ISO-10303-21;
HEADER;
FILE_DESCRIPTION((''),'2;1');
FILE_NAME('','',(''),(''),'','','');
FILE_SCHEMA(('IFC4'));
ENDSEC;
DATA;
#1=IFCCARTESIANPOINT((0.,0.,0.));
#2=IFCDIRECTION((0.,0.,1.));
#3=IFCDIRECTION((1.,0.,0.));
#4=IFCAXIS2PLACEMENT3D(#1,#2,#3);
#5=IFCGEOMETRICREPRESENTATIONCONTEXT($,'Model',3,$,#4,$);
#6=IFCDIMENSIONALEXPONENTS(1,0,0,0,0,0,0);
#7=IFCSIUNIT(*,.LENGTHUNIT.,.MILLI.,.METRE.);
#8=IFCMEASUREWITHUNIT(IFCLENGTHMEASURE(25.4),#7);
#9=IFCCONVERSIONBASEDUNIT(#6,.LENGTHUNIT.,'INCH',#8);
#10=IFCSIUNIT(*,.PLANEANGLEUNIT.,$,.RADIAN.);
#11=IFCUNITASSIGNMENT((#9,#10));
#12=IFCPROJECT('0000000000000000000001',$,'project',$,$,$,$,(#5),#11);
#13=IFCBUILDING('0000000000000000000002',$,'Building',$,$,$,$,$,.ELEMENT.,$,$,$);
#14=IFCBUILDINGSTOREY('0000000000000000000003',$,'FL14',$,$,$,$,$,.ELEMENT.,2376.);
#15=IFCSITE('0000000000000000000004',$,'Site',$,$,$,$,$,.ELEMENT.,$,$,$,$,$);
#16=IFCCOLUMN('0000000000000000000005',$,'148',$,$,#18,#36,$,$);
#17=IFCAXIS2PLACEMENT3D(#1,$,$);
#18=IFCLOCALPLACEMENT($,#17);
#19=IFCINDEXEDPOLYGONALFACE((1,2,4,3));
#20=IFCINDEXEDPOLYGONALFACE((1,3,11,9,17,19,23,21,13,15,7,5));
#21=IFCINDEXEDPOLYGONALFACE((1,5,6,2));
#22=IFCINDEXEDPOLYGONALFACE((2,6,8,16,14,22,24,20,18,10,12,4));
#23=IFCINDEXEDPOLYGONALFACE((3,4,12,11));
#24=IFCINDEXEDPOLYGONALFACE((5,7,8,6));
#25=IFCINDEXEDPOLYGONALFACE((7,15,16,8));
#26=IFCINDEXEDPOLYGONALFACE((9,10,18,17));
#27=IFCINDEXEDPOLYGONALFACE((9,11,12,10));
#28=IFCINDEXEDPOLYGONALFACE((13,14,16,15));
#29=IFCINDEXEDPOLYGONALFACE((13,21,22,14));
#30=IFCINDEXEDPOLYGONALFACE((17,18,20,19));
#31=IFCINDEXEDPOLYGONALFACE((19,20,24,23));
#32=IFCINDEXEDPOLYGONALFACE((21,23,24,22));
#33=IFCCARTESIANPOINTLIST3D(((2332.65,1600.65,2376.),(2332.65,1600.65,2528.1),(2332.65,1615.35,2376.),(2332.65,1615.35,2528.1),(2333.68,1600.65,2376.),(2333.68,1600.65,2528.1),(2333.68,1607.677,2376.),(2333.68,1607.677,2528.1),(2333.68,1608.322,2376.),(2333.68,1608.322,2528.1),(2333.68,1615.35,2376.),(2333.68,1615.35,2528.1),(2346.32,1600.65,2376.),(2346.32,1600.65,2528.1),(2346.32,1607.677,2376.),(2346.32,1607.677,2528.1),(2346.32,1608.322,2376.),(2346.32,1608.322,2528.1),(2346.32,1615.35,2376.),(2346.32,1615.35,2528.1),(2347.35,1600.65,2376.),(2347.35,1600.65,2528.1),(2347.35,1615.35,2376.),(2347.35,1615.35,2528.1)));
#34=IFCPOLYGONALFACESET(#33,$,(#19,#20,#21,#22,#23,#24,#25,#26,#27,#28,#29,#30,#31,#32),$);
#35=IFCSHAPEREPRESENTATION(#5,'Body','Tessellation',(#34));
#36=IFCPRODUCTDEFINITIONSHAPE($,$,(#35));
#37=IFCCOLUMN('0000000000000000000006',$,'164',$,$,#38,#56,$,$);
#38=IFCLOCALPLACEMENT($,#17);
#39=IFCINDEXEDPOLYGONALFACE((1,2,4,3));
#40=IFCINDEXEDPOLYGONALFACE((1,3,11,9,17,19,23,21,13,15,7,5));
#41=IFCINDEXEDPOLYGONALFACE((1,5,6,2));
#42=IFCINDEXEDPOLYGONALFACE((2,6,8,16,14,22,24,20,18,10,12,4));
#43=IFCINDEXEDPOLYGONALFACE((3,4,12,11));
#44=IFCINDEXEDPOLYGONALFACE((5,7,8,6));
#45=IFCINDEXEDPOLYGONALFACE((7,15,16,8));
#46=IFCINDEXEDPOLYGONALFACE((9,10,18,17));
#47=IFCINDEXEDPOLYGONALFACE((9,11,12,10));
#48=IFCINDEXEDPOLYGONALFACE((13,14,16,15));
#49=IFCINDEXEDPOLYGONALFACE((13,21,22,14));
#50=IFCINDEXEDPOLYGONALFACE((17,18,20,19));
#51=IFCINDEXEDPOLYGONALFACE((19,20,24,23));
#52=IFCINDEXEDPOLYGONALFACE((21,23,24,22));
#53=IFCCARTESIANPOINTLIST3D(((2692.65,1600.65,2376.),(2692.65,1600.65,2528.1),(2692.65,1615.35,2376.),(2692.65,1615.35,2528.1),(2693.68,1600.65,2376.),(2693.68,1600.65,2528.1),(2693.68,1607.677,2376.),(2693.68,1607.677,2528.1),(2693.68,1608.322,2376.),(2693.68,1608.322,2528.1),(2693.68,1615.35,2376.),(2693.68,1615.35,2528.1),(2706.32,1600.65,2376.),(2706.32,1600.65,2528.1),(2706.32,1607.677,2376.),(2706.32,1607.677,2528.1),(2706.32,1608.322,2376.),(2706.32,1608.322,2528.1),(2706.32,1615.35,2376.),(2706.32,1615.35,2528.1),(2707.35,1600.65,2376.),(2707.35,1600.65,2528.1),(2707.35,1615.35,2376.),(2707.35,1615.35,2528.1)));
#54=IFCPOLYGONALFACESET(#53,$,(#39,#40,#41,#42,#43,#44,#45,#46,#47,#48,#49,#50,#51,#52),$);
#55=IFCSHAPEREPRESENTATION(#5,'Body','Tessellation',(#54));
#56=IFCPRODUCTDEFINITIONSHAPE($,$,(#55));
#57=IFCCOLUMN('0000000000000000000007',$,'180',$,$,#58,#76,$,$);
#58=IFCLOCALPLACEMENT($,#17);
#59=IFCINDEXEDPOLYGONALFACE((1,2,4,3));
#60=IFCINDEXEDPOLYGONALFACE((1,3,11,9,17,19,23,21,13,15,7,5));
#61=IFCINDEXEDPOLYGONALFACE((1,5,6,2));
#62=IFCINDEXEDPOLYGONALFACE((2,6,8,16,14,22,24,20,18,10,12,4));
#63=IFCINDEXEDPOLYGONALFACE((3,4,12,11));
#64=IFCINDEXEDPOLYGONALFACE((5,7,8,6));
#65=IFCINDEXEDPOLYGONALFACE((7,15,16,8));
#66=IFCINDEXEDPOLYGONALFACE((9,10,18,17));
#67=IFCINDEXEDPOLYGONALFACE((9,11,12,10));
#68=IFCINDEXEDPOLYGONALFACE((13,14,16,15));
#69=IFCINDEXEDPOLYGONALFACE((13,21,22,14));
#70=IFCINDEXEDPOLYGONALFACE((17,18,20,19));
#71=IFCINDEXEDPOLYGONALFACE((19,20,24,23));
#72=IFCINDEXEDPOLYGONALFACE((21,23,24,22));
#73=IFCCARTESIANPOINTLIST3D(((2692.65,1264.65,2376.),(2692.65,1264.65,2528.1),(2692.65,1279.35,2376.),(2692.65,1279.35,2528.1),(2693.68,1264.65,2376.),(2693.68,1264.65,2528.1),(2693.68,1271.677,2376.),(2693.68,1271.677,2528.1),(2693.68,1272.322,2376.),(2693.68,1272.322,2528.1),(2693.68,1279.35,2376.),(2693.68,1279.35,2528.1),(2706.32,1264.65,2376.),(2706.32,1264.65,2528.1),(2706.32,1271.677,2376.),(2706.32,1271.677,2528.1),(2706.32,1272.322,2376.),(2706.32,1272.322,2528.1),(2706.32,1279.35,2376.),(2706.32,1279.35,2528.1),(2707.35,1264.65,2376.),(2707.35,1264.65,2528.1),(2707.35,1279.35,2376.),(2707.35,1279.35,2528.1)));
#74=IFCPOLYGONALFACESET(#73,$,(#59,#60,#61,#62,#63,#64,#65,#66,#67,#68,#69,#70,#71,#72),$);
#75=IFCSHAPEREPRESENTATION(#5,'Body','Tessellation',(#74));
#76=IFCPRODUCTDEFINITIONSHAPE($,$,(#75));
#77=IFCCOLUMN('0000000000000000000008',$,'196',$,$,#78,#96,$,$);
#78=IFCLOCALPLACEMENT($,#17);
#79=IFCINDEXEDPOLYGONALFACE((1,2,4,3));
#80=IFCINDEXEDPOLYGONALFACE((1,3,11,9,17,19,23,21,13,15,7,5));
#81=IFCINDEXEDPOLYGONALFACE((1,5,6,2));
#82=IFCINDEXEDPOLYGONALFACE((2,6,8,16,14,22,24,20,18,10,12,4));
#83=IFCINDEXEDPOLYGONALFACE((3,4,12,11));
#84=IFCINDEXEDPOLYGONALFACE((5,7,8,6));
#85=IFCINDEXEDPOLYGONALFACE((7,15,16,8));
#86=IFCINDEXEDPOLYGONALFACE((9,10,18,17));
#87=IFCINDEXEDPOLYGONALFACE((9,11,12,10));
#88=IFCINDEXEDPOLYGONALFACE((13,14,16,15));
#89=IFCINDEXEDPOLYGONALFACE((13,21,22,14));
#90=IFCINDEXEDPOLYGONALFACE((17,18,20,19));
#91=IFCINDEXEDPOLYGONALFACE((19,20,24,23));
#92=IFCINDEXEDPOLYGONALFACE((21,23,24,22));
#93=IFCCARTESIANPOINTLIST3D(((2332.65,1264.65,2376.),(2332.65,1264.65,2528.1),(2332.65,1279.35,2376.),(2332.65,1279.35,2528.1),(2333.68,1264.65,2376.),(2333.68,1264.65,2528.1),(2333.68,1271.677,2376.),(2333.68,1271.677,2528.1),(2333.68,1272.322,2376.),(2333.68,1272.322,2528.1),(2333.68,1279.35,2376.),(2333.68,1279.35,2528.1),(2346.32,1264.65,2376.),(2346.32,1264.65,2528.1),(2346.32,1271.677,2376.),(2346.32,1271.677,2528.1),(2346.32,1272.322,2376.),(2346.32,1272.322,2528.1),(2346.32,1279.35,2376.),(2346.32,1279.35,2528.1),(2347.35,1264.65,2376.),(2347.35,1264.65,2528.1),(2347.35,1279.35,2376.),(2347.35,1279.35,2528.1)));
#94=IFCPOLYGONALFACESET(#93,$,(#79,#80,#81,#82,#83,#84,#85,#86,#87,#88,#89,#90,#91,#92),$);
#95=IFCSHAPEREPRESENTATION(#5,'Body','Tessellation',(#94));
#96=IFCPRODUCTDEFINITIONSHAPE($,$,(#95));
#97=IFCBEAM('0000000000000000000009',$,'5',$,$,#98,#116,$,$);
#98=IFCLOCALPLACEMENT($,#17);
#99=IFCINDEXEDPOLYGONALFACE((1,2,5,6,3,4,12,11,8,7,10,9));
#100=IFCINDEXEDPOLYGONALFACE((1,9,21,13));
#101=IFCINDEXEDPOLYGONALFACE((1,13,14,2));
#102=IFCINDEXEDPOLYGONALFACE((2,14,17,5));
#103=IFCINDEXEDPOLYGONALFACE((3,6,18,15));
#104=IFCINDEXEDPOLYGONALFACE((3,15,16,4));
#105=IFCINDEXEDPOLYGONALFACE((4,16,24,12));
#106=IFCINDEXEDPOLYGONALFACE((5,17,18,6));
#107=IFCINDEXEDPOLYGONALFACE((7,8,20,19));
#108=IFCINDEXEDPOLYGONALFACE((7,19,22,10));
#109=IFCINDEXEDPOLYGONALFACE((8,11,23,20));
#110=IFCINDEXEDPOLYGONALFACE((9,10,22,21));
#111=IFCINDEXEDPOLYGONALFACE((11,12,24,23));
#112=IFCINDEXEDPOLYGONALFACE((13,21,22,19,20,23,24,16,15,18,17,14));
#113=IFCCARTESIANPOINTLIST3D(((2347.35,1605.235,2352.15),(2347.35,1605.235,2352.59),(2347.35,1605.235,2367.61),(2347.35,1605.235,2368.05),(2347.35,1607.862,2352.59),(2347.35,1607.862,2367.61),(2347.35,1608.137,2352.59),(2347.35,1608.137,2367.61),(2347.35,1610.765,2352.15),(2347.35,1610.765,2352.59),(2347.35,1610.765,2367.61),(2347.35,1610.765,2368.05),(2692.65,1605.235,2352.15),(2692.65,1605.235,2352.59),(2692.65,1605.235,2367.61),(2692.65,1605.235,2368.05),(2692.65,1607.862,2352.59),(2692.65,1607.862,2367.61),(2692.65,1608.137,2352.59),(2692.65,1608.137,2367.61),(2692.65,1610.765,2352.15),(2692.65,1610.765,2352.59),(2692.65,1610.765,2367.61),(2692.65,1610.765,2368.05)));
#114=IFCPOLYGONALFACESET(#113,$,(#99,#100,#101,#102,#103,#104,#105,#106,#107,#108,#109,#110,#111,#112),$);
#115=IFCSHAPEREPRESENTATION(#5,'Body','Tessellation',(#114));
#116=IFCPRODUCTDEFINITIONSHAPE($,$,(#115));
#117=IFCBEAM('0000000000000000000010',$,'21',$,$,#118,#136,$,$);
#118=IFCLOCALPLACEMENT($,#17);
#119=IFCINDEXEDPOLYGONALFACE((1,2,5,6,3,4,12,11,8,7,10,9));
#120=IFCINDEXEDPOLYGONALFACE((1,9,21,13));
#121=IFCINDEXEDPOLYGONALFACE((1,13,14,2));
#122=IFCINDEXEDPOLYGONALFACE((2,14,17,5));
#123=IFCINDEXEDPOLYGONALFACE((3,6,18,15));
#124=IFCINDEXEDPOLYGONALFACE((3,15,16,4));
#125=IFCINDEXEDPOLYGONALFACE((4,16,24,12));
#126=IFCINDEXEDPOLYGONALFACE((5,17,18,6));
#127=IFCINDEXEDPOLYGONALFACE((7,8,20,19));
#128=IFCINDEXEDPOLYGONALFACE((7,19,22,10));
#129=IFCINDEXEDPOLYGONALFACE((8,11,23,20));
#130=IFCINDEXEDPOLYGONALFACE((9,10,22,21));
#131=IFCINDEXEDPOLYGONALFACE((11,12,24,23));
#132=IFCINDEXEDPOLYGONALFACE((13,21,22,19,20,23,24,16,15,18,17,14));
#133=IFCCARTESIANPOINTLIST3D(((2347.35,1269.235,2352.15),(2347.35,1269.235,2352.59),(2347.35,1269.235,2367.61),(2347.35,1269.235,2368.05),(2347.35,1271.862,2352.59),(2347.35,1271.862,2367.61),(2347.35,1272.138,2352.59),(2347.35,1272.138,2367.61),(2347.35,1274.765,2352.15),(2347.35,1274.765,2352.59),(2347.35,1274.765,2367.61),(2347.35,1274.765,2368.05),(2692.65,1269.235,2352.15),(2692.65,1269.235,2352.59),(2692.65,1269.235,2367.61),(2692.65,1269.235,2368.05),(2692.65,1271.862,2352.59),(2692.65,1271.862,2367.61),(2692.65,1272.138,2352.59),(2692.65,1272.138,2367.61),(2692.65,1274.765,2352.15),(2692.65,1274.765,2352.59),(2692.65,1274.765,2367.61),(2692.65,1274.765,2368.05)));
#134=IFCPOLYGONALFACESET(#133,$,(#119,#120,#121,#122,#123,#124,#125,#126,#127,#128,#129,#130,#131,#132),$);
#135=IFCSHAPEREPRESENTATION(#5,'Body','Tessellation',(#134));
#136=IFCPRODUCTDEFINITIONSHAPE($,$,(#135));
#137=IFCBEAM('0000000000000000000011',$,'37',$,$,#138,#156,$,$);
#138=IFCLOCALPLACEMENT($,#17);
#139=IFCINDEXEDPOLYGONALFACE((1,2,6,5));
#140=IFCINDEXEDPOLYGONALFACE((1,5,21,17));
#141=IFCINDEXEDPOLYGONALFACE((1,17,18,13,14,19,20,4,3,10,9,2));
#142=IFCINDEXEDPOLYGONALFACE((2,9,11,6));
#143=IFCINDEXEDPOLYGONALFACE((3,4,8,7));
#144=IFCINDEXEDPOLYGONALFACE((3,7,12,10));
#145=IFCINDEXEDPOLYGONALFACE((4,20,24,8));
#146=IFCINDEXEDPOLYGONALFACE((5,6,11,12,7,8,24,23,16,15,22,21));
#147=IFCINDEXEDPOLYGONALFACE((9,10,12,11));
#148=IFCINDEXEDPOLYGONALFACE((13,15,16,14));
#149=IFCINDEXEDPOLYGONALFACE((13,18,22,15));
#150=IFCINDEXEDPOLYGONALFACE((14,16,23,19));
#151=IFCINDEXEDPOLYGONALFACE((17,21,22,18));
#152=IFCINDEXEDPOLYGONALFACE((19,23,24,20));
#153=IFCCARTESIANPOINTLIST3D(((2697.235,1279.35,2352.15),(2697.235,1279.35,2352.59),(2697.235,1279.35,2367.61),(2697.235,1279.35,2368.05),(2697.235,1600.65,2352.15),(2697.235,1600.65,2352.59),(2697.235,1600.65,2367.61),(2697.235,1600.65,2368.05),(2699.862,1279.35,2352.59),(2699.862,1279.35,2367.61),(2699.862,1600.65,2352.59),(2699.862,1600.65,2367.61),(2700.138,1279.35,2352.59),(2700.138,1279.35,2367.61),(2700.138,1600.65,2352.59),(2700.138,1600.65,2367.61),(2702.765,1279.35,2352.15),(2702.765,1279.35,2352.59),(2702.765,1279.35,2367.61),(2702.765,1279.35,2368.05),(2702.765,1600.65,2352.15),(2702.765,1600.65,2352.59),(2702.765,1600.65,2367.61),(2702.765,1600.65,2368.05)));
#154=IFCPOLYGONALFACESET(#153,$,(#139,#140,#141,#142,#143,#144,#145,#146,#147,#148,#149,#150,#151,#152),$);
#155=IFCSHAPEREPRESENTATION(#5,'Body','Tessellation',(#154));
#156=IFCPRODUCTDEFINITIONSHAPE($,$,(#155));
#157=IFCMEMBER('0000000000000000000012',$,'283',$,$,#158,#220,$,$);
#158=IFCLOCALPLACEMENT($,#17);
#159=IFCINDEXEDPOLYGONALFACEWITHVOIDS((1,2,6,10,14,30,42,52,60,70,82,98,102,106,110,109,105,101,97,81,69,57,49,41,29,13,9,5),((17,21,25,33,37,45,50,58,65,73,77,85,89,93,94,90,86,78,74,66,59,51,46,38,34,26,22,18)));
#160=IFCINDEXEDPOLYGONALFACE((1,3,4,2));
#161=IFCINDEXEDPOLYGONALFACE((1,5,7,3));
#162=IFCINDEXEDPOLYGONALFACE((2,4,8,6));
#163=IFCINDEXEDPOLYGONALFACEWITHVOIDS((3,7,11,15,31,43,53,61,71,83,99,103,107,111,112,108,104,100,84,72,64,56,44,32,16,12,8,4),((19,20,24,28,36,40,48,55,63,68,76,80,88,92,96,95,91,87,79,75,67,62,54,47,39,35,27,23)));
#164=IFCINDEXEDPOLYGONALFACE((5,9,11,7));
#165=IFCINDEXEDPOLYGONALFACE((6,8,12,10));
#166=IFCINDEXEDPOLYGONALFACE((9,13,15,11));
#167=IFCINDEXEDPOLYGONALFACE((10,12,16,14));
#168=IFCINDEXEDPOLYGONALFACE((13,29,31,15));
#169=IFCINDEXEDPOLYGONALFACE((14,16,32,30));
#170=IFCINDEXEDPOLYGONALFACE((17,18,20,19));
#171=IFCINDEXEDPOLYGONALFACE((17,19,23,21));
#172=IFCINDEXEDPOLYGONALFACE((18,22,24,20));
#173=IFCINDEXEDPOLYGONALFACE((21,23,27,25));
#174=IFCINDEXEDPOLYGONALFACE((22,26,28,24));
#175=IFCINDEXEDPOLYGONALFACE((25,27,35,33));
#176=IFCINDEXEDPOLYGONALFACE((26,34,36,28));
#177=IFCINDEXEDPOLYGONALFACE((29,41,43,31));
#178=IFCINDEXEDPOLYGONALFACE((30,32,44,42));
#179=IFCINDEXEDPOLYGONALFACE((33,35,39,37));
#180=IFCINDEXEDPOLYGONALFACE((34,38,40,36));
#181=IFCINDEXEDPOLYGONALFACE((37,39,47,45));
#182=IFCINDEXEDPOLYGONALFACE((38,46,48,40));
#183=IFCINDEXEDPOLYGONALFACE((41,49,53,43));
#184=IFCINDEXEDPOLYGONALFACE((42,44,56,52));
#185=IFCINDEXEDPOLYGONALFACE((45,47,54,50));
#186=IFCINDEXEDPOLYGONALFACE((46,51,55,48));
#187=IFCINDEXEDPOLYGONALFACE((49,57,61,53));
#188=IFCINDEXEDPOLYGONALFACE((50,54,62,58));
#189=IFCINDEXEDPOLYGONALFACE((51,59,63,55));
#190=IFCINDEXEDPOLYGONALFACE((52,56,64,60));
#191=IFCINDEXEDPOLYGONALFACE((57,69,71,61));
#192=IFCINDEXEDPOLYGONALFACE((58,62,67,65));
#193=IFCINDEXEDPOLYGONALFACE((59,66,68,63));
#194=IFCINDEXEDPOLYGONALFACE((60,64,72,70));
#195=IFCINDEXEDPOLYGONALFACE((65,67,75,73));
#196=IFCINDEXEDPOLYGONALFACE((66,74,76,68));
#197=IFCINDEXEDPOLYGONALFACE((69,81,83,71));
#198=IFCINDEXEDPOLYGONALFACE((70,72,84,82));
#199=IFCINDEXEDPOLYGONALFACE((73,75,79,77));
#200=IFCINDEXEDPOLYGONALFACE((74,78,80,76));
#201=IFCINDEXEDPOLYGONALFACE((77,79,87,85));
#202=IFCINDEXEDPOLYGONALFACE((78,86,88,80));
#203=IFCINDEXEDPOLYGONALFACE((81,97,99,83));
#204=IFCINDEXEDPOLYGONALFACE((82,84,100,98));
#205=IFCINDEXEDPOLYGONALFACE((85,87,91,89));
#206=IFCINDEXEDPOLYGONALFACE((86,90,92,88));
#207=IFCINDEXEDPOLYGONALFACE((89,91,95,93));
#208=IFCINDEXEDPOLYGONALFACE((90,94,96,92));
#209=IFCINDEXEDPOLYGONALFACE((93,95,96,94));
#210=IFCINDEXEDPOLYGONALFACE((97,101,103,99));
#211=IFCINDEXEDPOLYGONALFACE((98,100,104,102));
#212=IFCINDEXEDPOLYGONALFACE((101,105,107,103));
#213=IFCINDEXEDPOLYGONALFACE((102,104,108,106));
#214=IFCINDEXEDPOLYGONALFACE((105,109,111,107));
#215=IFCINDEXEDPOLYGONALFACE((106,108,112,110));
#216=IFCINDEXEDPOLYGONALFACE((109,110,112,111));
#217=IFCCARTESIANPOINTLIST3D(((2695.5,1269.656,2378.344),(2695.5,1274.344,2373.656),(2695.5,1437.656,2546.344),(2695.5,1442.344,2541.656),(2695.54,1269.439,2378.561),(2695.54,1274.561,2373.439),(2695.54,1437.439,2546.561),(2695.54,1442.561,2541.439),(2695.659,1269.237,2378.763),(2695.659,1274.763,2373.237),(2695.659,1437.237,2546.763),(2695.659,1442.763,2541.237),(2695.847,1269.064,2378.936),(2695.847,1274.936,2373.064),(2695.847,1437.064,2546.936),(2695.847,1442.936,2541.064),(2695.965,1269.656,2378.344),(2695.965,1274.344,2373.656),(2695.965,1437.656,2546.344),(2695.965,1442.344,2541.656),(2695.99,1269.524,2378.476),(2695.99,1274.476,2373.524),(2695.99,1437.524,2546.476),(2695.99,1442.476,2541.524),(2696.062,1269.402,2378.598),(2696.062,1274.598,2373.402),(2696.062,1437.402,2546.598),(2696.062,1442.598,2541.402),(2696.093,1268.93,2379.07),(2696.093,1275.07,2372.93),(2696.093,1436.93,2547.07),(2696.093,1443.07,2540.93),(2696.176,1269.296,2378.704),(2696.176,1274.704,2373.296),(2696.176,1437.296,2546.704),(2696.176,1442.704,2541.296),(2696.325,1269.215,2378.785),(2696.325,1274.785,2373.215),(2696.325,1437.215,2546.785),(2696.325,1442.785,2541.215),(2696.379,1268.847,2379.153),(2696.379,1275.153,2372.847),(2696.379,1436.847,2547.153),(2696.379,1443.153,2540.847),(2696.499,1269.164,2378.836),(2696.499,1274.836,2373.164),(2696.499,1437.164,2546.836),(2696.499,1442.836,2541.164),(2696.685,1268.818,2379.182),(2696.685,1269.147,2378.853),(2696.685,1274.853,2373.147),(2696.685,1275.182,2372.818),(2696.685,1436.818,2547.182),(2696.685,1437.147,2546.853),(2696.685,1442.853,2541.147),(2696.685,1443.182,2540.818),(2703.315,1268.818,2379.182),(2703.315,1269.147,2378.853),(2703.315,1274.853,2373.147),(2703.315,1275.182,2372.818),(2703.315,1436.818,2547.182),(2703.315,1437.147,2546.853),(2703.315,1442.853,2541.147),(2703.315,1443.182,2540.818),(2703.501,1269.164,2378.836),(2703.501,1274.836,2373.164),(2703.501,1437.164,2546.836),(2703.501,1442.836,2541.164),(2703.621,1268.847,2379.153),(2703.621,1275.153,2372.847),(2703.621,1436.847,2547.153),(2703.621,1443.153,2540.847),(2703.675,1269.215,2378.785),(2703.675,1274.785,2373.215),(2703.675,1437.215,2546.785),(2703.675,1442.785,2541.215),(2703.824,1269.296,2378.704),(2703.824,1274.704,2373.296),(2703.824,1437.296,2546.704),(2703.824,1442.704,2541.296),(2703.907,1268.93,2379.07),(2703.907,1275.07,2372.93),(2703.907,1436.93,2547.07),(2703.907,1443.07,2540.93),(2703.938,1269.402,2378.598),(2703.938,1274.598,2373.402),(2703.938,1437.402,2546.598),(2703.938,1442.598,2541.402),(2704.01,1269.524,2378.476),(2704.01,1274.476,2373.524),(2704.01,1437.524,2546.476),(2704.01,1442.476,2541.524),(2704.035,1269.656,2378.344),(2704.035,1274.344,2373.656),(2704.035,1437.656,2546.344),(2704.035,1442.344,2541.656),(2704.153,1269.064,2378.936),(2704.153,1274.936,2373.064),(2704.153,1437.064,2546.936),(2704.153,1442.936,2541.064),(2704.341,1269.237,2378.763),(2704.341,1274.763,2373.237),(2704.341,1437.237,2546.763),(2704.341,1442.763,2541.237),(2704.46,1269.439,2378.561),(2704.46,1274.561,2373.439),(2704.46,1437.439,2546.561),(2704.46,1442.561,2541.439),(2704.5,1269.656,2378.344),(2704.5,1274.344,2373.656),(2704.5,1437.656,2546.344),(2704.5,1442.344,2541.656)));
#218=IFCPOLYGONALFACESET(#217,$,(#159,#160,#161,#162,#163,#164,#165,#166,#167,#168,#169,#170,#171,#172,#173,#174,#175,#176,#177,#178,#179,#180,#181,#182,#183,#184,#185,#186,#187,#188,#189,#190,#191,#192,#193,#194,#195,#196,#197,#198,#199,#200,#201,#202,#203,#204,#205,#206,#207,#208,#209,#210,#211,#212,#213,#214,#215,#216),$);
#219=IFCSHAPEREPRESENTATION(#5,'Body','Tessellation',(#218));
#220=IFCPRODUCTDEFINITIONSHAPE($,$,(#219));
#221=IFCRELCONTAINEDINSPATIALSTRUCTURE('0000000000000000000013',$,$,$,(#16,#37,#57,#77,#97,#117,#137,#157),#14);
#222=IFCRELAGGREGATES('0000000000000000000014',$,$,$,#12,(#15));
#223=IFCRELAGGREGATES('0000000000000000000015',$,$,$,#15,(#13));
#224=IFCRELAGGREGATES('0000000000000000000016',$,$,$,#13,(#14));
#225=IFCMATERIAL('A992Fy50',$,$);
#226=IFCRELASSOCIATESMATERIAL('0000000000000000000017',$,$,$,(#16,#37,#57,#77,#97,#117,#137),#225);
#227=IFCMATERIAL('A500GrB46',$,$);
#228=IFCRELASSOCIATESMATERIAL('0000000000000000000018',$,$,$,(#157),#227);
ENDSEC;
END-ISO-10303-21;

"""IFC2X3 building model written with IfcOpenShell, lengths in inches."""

from ifc_helpers import new_model, entity, si_unit, converted_unit, frame, origin_with_axes, origin_2d_with_axis, place, context, project, spatial, hollow_rectangle, i_section, transform_2d, derived_profile, extrude, material, element, save


model = new_model("IFC2X3")

# Units and contexts
model_context = context("Model", 3, world=origin_with_axes())
ifc_project = project(units=[converted_unit("LENGTHUNIT", "INCH", entity("IfcLengthMeasure", 25.4), si_unit("LENGTHUNIT", "METRE", prefix="MILLI"), dimensions=[1, 0, 0, 0, 0, 0, 0]), si_unit("PLANEANGLEUNIT", "RADIAN")], contexts=[model_context])

# Site, building, storey
site = spatial("IfcSite", under=ifc_project, Name="Site", CompositionType="ELEMENT")
building = spatial("IfcBuilding", under=site, Name="Building", CompositionType="ELEMENT")
storey = spatial("IfcBuildingStorey", under=building, Name="FL14", CompositionType="ELEMENT", Elevation=2376.0)

# Columns
ifc_material_1 = material(Name="A992Fy50")
for number, where, z_axis, x_axis, name in (
    (1, (2340.0, 1608.0, 2376.0), (0.0, 0.0, 1.0), (0.0, -1.0, 0.0), "148"),
    (2, (2700.0, 1608.0, 2376.0), (0.0, 0.0, 1.0), (0.0, -1.0, 0.0), "164"),
    (3, (2700.0, 1272.0, 2376.0), (0.0, 0.0, 1.0), (0.0, -1.0, 0.0), "180"),
    (4, (2340.0, 1272.0, 2376.0), (0.0, 0.0, 1.0), (0.0, -1.0, 0.0), "196"),
):
    element("IfcColumn", number, at=place(None, frame(where, z_axis=z_axis, x_axis=x_axis)), inside=storey, material=ifc_material_1, Name=name, context=model_context, shape_type="SweptSolid", body=[
        extrude(i_section(OverallWidth=14.7, OverallDepth=14.7, WebThickness=0.645, FlangeThickness=1.03, at=origin_2d_with_axis()), origin_with_axes(), (0.0, 0.0, 1.0), 152.1),
    ])

# Beams
for number, where, z_axis, x_axis, name in (
    (5, (2347.35, 1608.0, 2376.0), (1.0, 0.0, 0.0), (0.0, 1.0, 0.0), "5"),
    (6, (2347.35, 1272.0, 2376.0), (1.0, 0.0, 0.0), (0.0, 1.0, 0.0), "21"),
):
    element("IfcBeam", number, at=place(None, frame(where, z_axis=z_axis, x_axis=x_axis)), inside=storey, material=ifc_material_1, Name=name, context=model_context, shape_type="SweptSolid", body=[
        extrude(derived_profile(i_section(OverallWidth=5.53, OverallDepth=15.9, WebThickness=0.275, FlangeThickness=0.44, at=origin_2d_with_axis()), transform_2d((0.0, -7.95))), origin_with_axes(), (0.0, 0.0, 1.0), 345.3),
    ])
beam_placement = place(None, frame((2700.0, 1279.35, 2376.0), z_axis=(0.0, 1.0, 0.0), x_axis=(-1.0, 0.0, 0.0)))
element("IfcBeam", 7, at=beam_placement, inside=storey, material=ifc_material_1, Name="37", context=model_context, shape_type="SweptSolid", body=[
    extrude(derived_profile(i_section(OverallWidth=5.53, OverallDepth=15.9, WebThickness=0.275, FlangeThickness=0.44, at=origin_2d_with_axis()), transform_2d((0.0, -7.95))), origin_with_axes(), (0.0, 0.0, 1.0), 321.3),
])

# Member
ifc_material_2 = material(Name="A500GrB46")
for number, where, z_axis, x_axis, name in (
    (8, (2700.0, 1272.0, 2376.0), (0.0, 0.707107, 0.707107), (-1.0, 0.0, 0.0), "283"),
):
    element("IfcMember", number, at=place(None, frame(where, z_axis=z_axis, x_axis=x_axis)), inside=storey, material=ifc_material_2, Name=name, context=model_context, shape_type="SweptSolid", body=[
        extrude(hollow_rectangle(XDim=9.0, YDim=9.0, WallThickness=0.465, InnerFilletRadius=0.72, OuterFilletRadius=1.185, at=origin_2d_with_axis()), origin_with_axes(), (0.0, 0.0, 1.0), 237.588),
    ])

save(model, "model.ifc")
